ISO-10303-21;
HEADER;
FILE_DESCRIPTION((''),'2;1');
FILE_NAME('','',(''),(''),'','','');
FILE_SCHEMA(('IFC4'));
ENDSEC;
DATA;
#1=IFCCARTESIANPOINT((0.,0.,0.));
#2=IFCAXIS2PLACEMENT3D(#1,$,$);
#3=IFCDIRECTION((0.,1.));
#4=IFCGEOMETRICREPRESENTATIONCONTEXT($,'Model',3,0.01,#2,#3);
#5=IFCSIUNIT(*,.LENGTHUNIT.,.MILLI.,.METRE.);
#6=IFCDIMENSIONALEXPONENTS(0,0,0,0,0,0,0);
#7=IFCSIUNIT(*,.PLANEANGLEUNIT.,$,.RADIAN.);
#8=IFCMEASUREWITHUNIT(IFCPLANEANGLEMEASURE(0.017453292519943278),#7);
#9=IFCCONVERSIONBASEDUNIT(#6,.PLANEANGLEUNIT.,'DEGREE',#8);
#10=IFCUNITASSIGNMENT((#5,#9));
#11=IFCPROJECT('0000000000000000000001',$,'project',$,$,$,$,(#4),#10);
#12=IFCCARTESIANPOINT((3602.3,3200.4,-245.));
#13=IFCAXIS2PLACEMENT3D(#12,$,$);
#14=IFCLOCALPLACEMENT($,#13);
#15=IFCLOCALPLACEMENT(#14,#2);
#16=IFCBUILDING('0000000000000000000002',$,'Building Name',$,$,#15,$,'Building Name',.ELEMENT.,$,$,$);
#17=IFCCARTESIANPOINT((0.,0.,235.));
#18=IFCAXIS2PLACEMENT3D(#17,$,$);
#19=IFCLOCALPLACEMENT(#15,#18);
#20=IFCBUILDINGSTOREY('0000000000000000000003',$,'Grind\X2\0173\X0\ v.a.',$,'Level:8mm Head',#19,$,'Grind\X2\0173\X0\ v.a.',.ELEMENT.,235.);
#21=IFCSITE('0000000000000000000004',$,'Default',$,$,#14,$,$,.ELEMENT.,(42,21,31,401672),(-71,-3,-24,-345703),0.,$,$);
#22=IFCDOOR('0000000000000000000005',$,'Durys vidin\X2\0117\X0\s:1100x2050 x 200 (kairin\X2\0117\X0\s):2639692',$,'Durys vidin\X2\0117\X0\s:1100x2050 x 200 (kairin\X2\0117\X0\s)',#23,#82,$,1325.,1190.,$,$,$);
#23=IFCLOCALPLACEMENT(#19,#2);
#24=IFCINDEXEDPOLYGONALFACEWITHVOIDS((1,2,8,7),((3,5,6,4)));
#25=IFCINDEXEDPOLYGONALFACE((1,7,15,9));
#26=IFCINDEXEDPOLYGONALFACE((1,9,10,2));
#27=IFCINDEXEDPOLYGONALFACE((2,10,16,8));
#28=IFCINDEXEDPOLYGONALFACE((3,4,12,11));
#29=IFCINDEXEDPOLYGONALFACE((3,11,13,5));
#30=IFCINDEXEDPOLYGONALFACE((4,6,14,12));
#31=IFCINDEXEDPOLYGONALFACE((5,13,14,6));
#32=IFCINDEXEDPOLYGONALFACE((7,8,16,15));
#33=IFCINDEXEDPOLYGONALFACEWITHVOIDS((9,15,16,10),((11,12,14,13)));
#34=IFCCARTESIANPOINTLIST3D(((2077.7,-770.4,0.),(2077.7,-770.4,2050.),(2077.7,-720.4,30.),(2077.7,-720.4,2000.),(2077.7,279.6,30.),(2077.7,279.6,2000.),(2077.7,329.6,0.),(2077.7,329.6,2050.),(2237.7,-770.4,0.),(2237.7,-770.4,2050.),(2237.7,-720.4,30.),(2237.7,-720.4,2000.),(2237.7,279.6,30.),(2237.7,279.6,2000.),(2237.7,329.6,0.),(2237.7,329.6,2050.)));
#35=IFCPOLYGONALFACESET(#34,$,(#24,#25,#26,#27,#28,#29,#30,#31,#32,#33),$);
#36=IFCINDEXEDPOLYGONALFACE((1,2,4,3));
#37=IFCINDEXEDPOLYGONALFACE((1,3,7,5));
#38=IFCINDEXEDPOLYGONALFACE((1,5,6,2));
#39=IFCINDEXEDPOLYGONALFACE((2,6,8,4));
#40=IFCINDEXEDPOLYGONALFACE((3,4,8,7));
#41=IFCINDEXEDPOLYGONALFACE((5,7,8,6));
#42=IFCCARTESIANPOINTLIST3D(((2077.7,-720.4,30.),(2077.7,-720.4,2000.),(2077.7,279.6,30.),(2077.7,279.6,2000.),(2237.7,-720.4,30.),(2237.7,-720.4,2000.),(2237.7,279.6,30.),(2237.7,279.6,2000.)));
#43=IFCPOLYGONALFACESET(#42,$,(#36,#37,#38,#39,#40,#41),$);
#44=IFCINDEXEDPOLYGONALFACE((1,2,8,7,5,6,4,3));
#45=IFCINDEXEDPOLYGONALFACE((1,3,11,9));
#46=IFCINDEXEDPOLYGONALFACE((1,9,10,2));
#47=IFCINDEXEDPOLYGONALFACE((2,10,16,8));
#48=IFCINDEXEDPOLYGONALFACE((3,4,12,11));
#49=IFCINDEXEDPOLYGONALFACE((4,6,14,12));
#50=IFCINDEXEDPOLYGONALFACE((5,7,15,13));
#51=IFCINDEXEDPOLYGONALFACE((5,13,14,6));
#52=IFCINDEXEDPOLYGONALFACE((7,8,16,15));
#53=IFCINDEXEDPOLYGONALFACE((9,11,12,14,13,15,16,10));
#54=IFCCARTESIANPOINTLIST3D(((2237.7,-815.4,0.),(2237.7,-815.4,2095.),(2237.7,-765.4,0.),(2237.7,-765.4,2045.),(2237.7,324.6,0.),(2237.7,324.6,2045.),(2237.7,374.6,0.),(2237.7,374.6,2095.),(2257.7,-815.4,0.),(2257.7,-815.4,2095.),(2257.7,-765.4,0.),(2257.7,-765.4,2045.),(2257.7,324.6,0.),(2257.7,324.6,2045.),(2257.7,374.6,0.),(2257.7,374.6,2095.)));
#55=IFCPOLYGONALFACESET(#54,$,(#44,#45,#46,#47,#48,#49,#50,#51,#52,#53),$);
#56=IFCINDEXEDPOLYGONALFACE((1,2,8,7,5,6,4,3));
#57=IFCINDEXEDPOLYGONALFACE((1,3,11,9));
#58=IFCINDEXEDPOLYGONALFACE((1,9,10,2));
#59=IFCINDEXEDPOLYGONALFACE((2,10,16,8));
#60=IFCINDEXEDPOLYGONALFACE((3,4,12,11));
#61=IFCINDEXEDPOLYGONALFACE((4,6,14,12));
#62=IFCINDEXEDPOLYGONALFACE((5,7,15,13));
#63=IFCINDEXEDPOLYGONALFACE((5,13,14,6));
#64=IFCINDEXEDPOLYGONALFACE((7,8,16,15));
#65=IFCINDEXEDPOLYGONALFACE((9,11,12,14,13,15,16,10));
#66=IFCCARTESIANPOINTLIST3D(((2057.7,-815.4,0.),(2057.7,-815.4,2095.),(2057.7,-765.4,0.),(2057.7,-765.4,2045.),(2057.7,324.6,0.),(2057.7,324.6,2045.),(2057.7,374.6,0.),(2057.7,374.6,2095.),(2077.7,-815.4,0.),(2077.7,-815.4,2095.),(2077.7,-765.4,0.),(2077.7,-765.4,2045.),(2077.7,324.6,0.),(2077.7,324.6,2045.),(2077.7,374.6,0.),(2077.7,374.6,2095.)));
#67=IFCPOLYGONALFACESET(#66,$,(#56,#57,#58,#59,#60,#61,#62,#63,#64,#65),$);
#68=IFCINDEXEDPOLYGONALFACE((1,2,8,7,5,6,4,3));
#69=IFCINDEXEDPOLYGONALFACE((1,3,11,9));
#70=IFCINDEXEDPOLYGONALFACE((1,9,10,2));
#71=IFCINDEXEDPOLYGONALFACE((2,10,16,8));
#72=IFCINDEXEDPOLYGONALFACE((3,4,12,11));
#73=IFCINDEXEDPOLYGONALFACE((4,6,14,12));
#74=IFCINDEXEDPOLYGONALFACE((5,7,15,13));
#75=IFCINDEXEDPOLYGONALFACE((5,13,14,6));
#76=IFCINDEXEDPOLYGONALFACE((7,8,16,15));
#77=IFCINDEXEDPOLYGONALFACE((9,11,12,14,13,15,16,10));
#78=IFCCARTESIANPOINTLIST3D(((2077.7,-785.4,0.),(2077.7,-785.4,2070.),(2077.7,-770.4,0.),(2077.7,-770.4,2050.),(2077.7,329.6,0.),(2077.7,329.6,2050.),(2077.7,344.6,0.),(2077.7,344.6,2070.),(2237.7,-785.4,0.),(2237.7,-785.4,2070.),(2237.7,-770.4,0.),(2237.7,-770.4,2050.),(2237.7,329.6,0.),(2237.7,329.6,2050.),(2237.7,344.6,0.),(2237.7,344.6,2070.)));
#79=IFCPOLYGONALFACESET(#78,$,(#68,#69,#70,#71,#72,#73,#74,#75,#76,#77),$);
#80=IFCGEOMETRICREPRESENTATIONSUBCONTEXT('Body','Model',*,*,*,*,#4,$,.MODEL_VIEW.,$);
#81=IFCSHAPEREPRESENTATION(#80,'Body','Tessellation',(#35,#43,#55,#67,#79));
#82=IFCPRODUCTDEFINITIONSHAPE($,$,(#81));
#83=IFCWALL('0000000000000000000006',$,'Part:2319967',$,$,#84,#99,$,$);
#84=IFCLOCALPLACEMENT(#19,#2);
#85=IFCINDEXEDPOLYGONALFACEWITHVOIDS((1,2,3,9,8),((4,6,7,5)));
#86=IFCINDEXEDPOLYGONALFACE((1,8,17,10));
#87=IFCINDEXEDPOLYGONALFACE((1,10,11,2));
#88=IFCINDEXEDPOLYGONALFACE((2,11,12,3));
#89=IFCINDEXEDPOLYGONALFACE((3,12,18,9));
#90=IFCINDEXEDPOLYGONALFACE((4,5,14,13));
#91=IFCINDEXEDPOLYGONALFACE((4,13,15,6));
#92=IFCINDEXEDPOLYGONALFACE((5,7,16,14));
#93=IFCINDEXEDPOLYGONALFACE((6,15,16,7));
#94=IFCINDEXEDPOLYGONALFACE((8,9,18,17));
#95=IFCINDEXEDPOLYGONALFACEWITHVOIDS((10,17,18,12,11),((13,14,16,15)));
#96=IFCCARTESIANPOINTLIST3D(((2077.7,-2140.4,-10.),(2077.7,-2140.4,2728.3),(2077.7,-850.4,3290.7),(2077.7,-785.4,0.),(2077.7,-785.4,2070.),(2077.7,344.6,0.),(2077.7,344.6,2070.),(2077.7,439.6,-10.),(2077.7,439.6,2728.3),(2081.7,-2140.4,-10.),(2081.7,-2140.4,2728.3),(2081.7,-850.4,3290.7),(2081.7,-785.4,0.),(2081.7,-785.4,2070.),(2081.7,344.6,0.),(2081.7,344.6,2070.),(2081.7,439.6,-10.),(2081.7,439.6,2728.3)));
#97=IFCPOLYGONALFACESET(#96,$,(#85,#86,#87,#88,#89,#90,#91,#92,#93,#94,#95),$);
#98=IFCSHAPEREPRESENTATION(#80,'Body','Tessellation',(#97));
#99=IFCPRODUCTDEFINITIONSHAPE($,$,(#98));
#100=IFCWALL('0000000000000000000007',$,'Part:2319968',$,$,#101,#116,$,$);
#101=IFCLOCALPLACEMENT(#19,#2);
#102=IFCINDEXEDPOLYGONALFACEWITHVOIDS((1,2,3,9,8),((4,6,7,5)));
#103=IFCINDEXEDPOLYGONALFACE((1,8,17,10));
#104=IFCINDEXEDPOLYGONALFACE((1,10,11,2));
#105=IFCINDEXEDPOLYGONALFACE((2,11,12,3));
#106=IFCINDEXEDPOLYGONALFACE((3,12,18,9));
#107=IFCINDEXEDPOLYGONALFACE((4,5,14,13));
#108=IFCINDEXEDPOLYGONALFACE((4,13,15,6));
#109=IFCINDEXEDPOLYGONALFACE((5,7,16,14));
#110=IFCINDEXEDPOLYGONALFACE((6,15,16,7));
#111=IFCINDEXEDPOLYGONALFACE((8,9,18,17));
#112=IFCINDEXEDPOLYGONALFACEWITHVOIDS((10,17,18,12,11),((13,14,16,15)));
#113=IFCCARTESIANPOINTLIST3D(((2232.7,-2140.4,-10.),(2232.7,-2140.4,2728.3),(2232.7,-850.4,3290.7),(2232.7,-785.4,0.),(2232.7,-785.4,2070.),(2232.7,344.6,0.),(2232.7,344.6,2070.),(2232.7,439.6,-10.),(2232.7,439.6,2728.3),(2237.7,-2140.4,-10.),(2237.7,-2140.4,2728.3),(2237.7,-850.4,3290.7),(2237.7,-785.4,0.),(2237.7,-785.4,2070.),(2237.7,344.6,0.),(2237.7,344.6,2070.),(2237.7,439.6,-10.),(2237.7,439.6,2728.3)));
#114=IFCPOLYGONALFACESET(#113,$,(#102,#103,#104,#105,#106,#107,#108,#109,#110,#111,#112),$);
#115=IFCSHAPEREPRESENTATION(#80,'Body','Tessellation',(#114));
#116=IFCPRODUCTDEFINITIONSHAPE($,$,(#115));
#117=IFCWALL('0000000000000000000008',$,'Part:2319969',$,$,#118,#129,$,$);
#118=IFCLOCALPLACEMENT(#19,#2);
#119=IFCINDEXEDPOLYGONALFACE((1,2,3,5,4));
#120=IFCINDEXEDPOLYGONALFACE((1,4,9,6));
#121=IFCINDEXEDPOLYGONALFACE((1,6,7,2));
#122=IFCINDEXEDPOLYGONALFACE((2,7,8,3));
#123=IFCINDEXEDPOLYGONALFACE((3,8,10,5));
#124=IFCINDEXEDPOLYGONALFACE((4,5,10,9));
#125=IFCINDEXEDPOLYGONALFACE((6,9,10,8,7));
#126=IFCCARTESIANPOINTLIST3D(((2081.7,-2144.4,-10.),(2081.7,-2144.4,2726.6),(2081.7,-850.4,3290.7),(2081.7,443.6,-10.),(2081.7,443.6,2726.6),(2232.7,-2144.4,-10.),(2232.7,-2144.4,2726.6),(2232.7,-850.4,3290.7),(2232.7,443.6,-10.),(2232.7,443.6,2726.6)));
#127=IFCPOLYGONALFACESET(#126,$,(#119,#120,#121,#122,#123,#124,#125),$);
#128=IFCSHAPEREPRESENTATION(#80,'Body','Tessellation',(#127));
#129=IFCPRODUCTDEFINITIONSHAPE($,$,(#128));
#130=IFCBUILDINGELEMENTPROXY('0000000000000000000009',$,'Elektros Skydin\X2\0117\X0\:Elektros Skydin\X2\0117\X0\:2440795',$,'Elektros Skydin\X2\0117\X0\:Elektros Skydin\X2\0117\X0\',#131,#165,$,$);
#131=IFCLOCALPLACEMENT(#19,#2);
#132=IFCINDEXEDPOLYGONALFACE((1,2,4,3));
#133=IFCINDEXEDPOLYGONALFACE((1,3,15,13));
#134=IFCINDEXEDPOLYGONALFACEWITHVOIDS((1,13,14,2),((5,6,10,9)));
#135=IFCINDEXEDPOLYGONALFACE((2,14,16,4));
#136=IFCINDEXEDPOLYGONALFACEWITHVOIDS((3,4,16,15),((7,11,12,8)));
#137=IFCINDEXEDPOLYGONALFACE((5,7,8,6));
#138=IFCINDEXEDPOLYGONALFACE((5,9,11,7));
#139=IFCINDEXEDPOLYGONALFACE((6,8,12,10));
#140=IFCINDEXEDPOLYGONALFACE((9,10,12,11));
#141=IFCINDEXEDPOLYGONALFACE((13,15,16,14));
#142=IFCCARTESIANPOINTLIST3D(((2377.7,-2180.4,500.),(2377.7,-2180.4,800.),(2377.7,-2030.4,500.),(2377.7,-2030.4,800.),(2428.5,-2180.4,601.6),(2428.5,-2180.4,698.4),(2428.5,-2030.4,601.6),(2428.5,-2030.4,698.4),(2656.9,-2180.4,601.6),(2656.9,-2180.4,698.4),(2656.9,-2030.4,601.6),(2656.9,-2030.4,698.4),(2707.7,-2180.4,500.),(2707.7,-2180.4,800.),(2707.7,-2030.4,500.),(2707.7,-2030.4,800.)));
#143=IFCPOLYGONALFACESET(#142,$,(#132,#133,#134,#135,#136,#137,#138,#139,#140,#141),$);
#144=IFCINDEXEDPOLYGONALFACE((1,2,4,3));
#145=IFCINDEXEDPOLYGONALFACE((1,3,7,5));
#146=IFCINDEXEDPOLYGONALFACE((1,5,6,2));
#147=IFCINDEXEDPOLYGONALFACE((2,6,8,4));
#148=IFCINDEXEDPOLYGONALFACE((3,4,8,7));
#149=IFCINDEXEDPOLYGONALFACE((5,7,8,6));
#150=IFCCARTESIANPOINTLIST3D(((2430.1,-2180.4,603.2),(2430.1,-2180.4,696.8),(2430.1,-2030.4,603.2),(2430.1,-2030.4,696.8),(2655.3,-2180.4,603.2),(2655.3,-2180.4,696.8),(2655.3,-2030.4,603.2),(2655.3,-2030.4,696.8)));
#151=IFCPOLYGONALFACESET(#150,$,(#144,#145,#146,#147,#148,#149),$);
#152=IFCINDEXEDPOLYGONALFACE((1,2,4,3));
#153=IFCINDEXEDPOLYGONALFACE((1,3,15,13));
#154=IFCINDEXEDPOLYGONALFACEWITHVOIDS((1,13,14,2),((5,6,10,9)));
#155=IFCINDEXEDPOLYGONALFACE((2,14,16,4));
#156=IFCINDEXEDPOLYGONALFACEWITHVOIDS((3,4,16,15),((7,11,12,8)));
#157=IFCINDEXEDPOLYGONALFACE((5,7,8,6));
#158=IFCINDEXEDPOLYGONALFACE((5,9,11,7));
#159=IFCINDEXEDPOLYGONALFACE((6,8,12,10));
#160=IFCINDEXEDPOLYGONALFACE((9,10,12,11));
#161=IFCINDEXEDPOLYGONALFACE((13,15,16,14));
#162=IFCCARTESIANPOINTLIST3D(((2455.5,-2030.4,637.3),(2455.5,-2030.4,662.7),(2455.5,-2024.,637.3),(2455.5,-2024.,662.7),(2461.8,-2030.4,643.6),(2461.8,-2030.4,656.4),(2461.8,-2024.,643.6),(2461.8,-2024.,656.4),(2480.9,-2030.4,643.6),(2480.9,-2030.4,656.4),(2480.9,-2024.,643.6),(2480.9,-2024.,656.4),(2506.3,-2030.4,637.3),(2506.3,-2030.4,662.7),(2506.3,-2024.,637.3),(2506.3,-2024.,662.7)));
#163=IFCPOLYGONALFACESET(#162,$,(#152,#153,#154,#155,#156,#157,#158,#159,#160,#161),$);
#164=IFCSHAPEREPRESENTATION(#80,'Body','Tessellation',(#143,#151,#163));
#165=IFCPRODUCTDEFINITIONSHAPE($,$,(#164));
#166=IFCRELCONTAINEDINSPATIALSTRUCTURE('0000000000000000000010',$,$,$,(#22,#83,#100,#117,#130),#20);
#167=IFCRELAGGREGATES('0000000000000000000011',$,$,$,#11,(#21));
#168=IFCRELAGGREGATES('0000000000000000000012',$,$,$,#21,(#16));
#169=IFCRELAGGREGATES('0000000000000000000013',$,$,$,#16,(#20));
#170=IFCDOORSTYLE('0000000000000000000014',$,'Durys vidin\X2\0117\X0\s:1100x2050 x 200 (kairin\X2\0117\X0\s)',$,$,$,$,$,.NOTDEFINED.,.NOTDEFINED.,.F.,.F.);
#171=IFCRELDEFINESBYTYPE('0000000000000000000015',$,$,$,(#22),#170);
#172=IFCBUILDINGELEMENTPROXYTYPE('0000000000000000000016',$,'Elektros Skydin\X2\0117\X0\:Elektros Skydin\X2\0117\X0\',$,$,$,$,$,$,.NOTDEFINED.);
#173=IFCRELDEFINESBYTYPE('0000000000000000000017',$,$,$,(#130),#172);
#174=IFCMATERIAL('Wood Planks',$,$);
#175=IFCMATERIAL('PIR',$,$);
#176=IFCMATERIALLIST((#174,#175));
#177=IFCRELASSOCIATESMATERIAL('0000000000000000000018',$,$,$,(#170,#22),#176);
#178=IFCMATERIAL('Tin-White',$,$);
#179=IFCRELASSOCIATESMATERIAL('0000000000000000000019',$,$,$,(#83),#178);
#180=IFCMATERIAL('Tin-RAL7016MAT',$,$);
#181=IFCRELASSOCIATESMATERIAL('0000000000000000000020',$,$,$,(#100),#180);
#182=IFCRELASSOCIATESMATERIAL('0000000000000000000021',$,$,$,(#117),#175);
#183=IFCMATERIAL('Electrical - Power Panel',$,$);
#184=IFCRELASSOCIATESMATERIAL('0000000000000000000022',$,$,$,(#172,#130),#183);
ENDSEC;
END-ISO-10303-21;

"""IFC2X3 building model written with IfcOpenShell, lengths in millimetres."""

from ifc_helpers import new_model, entity, si_unit, converted_unit, direction, frame, frame_2d, origin, origin_2d_with_axis, place, context, subcontext, project, spatial, polyline, rectangle, outline, extrude, boolean, clip, bounded_halfspace, source, transform, mapped, material, material_list, type_object, type_shapes, element, save


model = new_model("IFC2X3")

# Units and contexts
model_context = context("Model", 3, precision=0.01, world=origin(), true_north=direction((0.0, 1.0)))
body_context = subcontext(model_context, "Body", "Model", "MODEL_VIEW")
ifc_project = project(units=[si_unit("LENGTHUNIT", "METRE", prefix="MILLI"), converted_unit("PLANEANGLEUNIT", "DEGREE", entity("IfcPlaneAngleMeasure", 0.017453292519943278), si_unit("PLANEANGLEUNIT", "RADIAN"), dimensions=[0, 0, 0, 0, 0, 0, 0])], contexts=[model_context])

# Site, building, storey
site_placement = place(None, frame((3602.3, 3200.4, -245.0)))
site = spatial("IfcSite", under=ifc_project, at=site_placement, Name="Default", CompositionType="ELEMENT", RefLatitude=(42, 21, 31, 401672), RefLongitude=(-71, -3, -24, -345703), RefElevation=0.0)
building_placement = place(site_placement, origin())
building = spatial("IfcBuilding", under=site, at=building_placement, Name="Building Name", LongName="Building Name", CompositionType="ELEMENT")
storey_placement = place(building_placement, frame((0.0, 0.0, 235.0)))
storey = spatial("IfcBuildingStorey", under=building, at=storey_placement, Name="Grindų v.a.", ObjectType="Level:8mm Head", LongName="Grindų v.a.", CompositionType="ELEMENT", Elevation=235.0)

# Shared definitions
ifc_material_1 = material(Name="Wood Planks")
ifc_material_2 = material(Name="Tin-White")
ifc_material_3 = material(Name="PIR")
ifc_material_4 = material(Name="Tin-RAL7016MAT")

# Door
ifc_material_list_1 = material_list([ifc_material_1, ifc_material_3])
door_style_1 = type_object("IfcDoorStyle", Name="Durys vidinės:1100x2050 x 200 (kairinės)", ConstructionType="NOTDEFINED", OperationType="NOTDEFINED", ParameterTakesPrecedence=False, Sizeable=False, material=ifc_material_list_1)
shared_shape_1 = source(origin(), body_context, "Body", "SweptSolid", [
    extrude(outline(polyline([(-550.0, -1025.0), (550.0, -1025.0), (550.0, 1025.0), (-550.0, 1025.0), (-550.0, -1025.0)]), holes=[polyline([(-500.0, -975.0), (-500.0, 995.0), (500.0, 995.0), (500.0, -975.0), (-500.0, -975.0)])]), frame((0.0, -160.0, 1025.0), z_axis=(0.0, 1.0, 0.0), x_axis=(1.0, 0.0, 0.0)), (0.0, 0.0, 1.0), 160.0),
    extrude(rectangle(XDim=1000.0, YDim=160.0, at=origin_2d_with_axis()), frame((0.0, -80.0, 30.0), z_axis=(0.0, 0.0, 1.0), x_axis=(-1.0, 0.0, 0.0)), (0.0, 0.0, 1.0), 1970.0),
    extrude(outline(polyline([(-595.0, -1060.0), (595.0, -1060.0), (595.0, 1035.0), (545.0, 1035.0), (545.0, -1010.0), (-545.0, -1010.0), (-545.0, 1035.0), (-595.0, 1035.0), (-595.0, -1060.0)])), frame((0.0, 0.0, 1035.0), z_axis=(0.0, 1.0, 0.0), x_axis=(1.0, 0.0, 0.0)), (0.0, 0.0, 1.0), 20.0),
    extrude(outline(polyline([(-595.0, -1060.0), (595.0, -1060.0), (595.0, 1035.0), (545.0, 1035.0), (545.0, -1010.0), (-545.0, -1010.0), (-545.0, 1035.0), (-595.0, 1035.0), (-595.0, -1060.0)])), frame((0.0, -180.0, 1035.0), z_axis=(0.0, 1.0, 0.0), x_axis=(1.0, 0.0, 0.0)), (0.0, 0.0, 1.0), 20.0),
    extrude(outline(polyline([(-1030.0, -565.0), (1040.0, -565.0), (1040.0, 565.0), (-1030.0, 565.0), (-1030.0, 550.0), (1020.0, 550.0), (1020.0, -550.0), (-1030.0, -550.0), (-1030.0, -565.0)])), frame((0.0, -160.0, 1030.0), z_axis=(0.0, 1.0, 0.0), x_axis=(0.0, 0.0, 1.0)), (0.0, 0.0, 1.0), 160.0),
])
type_shapes(door_style_1, [shared_shape_1])
door_1_placement = place(storey_placement, frame((2237.7, -220.4, 0.0), z_axis=(0.0, 0.0, 1.0), x_axis=(0.0, -1.0, 0.0)))
element("IfcDoor", 1, at=door_1_placement, inside=storey, type_object=door_style_1, material=ifc_material_list_1, Name="Durys vidinės:1100x2050 x 200 (kairinės):2639692", ObjectType="Durys vidinės:1100x2050 x 200 (kairinės)", OverallHeight=1325.0, OverallWidth=1190.0, context=body_context, shape_type="MappedRepresentation", body=[
    mapped(shared_shape_1, transform((0.0, 0.0, 0.0), scale=1.0)),
])

# Walls
wall_1_placement = place(storey_placement, frame((0.0, 0.0, -10.0)))
element("IfcWall", 2, at=wall_1_placement, inside=storey, material=ifc_material_2, Name="Part:2319967", context=body_context, shape_type="CSG", body=[
    boolean("DIFFERENCE", clip(clip(extrude(rectangle(XDim=4.0, YDim=2580.0, at=frame_2d((0.0, 0.0), x_axis=(1.0, 0.0))), frame((2079.7, -850.4, 0.0)), (0.0, 0.0, 1.0), 3300.7), bounded_halfspace(frame((-4702.3, -2400.4, 2625.0), z_axis=(0.0, -0.399598, 0.91669), x_axis=(1.0, 0.0, 0.0)), False, frame((2079.7, -850.4, 0.0)), polyline([(2.0, 0.0), (-2.0, 0.0), (-2.0, -1290.0), (2.0, -1290.0), (2.0, 0.0)]))), bounded_halfspace(frame((4997.7, 699.6, 2625.0), z_axis=(0.0, 0.399598, 0.91669), x_axis=(-1.0, 0.0, 0.0)), False, frame((2079.7, -850.4, 0.0)), polyline([(-2.0, 0.0), (2.0, 0.0), (2.0, 1290.0), (-2.0, 1290.0), (-2.0, 0.0)]))), extrude(rectangle(XDim=2070.0, YDim=1130.0, at=frame_2d((0.0, 0.0), x_axis=(0.0, 1.0))), frame((2081.7, -220.4, 1045.0), z_axis=(-1.0, 0.0, 0.0), x_axis=(0.0, 1.0, 0.0)), (0.0, 0.0, 1.0), 4.0)),
])
wall_2_placement = place(storey_placement, frame((0.0, 0.0, -10.0)))
element("IfcWall", 3, at=wall_2_placement, inside=storey, material=ifc_material_4, Name="Part:2319968", context=body_context, shape_type="CSG", body=[
    boolean("DIFFERENCE", clip(clip(extrude(rectangle(XDim=5.0, YDim=2580.0, at=frame_2d((0.0, 0.0), x_axis=(1.0, 0.0))), frame((2235.2, -850.4, 0.0)), (0.0, 0.0, 1.0), 3300.7), bounded_halfspace(frame((-4702.3, -2400.4, 2625.0), z_axis=(0.0, -0.399598, 0.91669), x_axis=(1.0, 0.0, 0.0)), False, frame((2235.2, -850.4, 0.0)), polyline([(-2.5, -1290.0), (2.5, -1290.0), (2.5, 0.0), (-2.5, 0.0), (-2.5, -1290.0)]))), bounded_halfspace(frame((4997.7, 699.6, 2625.0), z_axis=(0.0, 0.399598, 0.91669), x_axis=(-1.0, 0.0, 0.0)), False, frame((2235.2, -850.4, 0.0)), polyline([(2.5, 1290.0), (-2.5, 1290.0), (-2.5, 0.0), (2.5, 0.0), (2.5, 1290.0)]))), extrude(rectangle(XDim=2070.0, YDim=1130.0, at=frame_2d((0.0, 0.0), x_axis=(0.0, 1.0))), frame((2237.7, -220.4, 1045.0), z_axis=(-1.0, 0.0, 0.0), x_axis=(0.0, 1.0, 0.0)), (0.0, 0.0, 1.0), 5.0)),
])
wall_3_placement = place(storey_placement, frame((0.0, 0.0, -10.0)))
element("IfcWall", 4, at=wall_3_placement, inside=storey, material=ifc_material_3, Name="Part:2319969", context=body_context, shape_type="Clipping", body=[
    clip(clip(extrude(rectangle(XDim=151.0, YDim=2588.0, at=frame_2d((0.0, 0.0), x_axis=(1.0, 0.0))), frame((2157.2, -850.4, 0.0)), (0.0, 0.0, 1.0), 3300.7), bounded_halfspace(frame((-4702.3, -2400.4, 2625.0), z_axis=(0.0, -0.399598, 0.91669), x_axis=(1.0, 0.0, 0.0)), False, frame((2157.2, -850.4, 0.0)), polyline([(-75.5, -1294.0), (75.5, -1294.0), (75.5, 0.0), (-75.5, 0.0), (-75.5, -1294.0)]))), bounded_halfspace(frame((4997.7, 699.6, 2625.0), z_axis=(0.0, 0.399598, 0.91669), x_axis=(-1.0, 0.0, 0.0)), False, frame((2157.2, -850.4, 0.0)), polyline([(75.5, 1294.0), (-75.5, 1294.0), (-75.5, 0.0), (75.5, 0.0), (75.5, 1294.0)]))),
])

# Building element proxy
ifc_material_5 = material(Name="Electrical - Power Panel")
building_element_proxy_type = type_object("IfcBuildingElementProxyType", Name="Elektros Skydinė:Elektros Skydinė", PredefinedType="NOTDEFINED", material=ifc_material_5)
shared_shape_2 = source(origin(), body_context, "Body", "SweptSolid", [
    extrude(outline(polyline([(-165.0, -150.0), (165.0, -150.0), (165.0, 150.0), (-165.0, 150.0), (-165.0, -150.0)]), holes=[polyline([(114.2, -48.4), (-114.2, -48.4), (-114.2, 48.4), (114.2, 48.4), (114.2, -48.4)])]), frame((0.0, -150.0, 650.0), z_axis=(0.0, 1.0, 0.0), x_axis=(1.0, 0.0, 0.0)), (0.0, 0.0, 1.0), 150.0),
    extrude(rectangle(XDim=225.2, YDim=150.0, at=origin_2d_with_axis()), frame((0.0, -75.0, 603.2)), (0.0, 0.0, 1.0), 93.6),
    extrude(outline(polyline([(-25.4, -12.7), (25.4, -12.7), (25.4, 12.7), (-25.4, 12.7), (-25.4, -12.7)]), holes=[polyline([(19.1, -6.4), (0.0, -6.4), (0.0, 6.4), (19.1, 6.4), (19.1, -6.4)])]), frame((61.8, -156.3, 650.0), z_axis=(0.0, 1.0, 0.0), x_axis=(1.0, 0.0, 0.0)), (0.0, 0.0, 1.0), 6.4),
])
type_shapes(building_element_proxy_type, [shared_shape_2])
proxy_placement = place(storey_placement, frame((2542.7, -2180.4, 0.0), z_axis=(0.0, 0.0, 1.0), x_axis=(-1.0, 0.0, 0.0)))
element("IfcBuildingElementProxy", 5, at=proxy_placement, inside=storey, type_object=building_element_proxy_type, material=ifc_material_5, Name="Elektros Skydinė:Elektros Skydinė:2440795", ObjectType="Elektros Skydinė:Elektros Skydinė", context=body_context, shape_type="MappedRepresentation", body=[
    mapped(shared_shape_2, transform((0.0, 0.0, 0.0), scale=1.0)),
])

save(model, "model.ifc")
